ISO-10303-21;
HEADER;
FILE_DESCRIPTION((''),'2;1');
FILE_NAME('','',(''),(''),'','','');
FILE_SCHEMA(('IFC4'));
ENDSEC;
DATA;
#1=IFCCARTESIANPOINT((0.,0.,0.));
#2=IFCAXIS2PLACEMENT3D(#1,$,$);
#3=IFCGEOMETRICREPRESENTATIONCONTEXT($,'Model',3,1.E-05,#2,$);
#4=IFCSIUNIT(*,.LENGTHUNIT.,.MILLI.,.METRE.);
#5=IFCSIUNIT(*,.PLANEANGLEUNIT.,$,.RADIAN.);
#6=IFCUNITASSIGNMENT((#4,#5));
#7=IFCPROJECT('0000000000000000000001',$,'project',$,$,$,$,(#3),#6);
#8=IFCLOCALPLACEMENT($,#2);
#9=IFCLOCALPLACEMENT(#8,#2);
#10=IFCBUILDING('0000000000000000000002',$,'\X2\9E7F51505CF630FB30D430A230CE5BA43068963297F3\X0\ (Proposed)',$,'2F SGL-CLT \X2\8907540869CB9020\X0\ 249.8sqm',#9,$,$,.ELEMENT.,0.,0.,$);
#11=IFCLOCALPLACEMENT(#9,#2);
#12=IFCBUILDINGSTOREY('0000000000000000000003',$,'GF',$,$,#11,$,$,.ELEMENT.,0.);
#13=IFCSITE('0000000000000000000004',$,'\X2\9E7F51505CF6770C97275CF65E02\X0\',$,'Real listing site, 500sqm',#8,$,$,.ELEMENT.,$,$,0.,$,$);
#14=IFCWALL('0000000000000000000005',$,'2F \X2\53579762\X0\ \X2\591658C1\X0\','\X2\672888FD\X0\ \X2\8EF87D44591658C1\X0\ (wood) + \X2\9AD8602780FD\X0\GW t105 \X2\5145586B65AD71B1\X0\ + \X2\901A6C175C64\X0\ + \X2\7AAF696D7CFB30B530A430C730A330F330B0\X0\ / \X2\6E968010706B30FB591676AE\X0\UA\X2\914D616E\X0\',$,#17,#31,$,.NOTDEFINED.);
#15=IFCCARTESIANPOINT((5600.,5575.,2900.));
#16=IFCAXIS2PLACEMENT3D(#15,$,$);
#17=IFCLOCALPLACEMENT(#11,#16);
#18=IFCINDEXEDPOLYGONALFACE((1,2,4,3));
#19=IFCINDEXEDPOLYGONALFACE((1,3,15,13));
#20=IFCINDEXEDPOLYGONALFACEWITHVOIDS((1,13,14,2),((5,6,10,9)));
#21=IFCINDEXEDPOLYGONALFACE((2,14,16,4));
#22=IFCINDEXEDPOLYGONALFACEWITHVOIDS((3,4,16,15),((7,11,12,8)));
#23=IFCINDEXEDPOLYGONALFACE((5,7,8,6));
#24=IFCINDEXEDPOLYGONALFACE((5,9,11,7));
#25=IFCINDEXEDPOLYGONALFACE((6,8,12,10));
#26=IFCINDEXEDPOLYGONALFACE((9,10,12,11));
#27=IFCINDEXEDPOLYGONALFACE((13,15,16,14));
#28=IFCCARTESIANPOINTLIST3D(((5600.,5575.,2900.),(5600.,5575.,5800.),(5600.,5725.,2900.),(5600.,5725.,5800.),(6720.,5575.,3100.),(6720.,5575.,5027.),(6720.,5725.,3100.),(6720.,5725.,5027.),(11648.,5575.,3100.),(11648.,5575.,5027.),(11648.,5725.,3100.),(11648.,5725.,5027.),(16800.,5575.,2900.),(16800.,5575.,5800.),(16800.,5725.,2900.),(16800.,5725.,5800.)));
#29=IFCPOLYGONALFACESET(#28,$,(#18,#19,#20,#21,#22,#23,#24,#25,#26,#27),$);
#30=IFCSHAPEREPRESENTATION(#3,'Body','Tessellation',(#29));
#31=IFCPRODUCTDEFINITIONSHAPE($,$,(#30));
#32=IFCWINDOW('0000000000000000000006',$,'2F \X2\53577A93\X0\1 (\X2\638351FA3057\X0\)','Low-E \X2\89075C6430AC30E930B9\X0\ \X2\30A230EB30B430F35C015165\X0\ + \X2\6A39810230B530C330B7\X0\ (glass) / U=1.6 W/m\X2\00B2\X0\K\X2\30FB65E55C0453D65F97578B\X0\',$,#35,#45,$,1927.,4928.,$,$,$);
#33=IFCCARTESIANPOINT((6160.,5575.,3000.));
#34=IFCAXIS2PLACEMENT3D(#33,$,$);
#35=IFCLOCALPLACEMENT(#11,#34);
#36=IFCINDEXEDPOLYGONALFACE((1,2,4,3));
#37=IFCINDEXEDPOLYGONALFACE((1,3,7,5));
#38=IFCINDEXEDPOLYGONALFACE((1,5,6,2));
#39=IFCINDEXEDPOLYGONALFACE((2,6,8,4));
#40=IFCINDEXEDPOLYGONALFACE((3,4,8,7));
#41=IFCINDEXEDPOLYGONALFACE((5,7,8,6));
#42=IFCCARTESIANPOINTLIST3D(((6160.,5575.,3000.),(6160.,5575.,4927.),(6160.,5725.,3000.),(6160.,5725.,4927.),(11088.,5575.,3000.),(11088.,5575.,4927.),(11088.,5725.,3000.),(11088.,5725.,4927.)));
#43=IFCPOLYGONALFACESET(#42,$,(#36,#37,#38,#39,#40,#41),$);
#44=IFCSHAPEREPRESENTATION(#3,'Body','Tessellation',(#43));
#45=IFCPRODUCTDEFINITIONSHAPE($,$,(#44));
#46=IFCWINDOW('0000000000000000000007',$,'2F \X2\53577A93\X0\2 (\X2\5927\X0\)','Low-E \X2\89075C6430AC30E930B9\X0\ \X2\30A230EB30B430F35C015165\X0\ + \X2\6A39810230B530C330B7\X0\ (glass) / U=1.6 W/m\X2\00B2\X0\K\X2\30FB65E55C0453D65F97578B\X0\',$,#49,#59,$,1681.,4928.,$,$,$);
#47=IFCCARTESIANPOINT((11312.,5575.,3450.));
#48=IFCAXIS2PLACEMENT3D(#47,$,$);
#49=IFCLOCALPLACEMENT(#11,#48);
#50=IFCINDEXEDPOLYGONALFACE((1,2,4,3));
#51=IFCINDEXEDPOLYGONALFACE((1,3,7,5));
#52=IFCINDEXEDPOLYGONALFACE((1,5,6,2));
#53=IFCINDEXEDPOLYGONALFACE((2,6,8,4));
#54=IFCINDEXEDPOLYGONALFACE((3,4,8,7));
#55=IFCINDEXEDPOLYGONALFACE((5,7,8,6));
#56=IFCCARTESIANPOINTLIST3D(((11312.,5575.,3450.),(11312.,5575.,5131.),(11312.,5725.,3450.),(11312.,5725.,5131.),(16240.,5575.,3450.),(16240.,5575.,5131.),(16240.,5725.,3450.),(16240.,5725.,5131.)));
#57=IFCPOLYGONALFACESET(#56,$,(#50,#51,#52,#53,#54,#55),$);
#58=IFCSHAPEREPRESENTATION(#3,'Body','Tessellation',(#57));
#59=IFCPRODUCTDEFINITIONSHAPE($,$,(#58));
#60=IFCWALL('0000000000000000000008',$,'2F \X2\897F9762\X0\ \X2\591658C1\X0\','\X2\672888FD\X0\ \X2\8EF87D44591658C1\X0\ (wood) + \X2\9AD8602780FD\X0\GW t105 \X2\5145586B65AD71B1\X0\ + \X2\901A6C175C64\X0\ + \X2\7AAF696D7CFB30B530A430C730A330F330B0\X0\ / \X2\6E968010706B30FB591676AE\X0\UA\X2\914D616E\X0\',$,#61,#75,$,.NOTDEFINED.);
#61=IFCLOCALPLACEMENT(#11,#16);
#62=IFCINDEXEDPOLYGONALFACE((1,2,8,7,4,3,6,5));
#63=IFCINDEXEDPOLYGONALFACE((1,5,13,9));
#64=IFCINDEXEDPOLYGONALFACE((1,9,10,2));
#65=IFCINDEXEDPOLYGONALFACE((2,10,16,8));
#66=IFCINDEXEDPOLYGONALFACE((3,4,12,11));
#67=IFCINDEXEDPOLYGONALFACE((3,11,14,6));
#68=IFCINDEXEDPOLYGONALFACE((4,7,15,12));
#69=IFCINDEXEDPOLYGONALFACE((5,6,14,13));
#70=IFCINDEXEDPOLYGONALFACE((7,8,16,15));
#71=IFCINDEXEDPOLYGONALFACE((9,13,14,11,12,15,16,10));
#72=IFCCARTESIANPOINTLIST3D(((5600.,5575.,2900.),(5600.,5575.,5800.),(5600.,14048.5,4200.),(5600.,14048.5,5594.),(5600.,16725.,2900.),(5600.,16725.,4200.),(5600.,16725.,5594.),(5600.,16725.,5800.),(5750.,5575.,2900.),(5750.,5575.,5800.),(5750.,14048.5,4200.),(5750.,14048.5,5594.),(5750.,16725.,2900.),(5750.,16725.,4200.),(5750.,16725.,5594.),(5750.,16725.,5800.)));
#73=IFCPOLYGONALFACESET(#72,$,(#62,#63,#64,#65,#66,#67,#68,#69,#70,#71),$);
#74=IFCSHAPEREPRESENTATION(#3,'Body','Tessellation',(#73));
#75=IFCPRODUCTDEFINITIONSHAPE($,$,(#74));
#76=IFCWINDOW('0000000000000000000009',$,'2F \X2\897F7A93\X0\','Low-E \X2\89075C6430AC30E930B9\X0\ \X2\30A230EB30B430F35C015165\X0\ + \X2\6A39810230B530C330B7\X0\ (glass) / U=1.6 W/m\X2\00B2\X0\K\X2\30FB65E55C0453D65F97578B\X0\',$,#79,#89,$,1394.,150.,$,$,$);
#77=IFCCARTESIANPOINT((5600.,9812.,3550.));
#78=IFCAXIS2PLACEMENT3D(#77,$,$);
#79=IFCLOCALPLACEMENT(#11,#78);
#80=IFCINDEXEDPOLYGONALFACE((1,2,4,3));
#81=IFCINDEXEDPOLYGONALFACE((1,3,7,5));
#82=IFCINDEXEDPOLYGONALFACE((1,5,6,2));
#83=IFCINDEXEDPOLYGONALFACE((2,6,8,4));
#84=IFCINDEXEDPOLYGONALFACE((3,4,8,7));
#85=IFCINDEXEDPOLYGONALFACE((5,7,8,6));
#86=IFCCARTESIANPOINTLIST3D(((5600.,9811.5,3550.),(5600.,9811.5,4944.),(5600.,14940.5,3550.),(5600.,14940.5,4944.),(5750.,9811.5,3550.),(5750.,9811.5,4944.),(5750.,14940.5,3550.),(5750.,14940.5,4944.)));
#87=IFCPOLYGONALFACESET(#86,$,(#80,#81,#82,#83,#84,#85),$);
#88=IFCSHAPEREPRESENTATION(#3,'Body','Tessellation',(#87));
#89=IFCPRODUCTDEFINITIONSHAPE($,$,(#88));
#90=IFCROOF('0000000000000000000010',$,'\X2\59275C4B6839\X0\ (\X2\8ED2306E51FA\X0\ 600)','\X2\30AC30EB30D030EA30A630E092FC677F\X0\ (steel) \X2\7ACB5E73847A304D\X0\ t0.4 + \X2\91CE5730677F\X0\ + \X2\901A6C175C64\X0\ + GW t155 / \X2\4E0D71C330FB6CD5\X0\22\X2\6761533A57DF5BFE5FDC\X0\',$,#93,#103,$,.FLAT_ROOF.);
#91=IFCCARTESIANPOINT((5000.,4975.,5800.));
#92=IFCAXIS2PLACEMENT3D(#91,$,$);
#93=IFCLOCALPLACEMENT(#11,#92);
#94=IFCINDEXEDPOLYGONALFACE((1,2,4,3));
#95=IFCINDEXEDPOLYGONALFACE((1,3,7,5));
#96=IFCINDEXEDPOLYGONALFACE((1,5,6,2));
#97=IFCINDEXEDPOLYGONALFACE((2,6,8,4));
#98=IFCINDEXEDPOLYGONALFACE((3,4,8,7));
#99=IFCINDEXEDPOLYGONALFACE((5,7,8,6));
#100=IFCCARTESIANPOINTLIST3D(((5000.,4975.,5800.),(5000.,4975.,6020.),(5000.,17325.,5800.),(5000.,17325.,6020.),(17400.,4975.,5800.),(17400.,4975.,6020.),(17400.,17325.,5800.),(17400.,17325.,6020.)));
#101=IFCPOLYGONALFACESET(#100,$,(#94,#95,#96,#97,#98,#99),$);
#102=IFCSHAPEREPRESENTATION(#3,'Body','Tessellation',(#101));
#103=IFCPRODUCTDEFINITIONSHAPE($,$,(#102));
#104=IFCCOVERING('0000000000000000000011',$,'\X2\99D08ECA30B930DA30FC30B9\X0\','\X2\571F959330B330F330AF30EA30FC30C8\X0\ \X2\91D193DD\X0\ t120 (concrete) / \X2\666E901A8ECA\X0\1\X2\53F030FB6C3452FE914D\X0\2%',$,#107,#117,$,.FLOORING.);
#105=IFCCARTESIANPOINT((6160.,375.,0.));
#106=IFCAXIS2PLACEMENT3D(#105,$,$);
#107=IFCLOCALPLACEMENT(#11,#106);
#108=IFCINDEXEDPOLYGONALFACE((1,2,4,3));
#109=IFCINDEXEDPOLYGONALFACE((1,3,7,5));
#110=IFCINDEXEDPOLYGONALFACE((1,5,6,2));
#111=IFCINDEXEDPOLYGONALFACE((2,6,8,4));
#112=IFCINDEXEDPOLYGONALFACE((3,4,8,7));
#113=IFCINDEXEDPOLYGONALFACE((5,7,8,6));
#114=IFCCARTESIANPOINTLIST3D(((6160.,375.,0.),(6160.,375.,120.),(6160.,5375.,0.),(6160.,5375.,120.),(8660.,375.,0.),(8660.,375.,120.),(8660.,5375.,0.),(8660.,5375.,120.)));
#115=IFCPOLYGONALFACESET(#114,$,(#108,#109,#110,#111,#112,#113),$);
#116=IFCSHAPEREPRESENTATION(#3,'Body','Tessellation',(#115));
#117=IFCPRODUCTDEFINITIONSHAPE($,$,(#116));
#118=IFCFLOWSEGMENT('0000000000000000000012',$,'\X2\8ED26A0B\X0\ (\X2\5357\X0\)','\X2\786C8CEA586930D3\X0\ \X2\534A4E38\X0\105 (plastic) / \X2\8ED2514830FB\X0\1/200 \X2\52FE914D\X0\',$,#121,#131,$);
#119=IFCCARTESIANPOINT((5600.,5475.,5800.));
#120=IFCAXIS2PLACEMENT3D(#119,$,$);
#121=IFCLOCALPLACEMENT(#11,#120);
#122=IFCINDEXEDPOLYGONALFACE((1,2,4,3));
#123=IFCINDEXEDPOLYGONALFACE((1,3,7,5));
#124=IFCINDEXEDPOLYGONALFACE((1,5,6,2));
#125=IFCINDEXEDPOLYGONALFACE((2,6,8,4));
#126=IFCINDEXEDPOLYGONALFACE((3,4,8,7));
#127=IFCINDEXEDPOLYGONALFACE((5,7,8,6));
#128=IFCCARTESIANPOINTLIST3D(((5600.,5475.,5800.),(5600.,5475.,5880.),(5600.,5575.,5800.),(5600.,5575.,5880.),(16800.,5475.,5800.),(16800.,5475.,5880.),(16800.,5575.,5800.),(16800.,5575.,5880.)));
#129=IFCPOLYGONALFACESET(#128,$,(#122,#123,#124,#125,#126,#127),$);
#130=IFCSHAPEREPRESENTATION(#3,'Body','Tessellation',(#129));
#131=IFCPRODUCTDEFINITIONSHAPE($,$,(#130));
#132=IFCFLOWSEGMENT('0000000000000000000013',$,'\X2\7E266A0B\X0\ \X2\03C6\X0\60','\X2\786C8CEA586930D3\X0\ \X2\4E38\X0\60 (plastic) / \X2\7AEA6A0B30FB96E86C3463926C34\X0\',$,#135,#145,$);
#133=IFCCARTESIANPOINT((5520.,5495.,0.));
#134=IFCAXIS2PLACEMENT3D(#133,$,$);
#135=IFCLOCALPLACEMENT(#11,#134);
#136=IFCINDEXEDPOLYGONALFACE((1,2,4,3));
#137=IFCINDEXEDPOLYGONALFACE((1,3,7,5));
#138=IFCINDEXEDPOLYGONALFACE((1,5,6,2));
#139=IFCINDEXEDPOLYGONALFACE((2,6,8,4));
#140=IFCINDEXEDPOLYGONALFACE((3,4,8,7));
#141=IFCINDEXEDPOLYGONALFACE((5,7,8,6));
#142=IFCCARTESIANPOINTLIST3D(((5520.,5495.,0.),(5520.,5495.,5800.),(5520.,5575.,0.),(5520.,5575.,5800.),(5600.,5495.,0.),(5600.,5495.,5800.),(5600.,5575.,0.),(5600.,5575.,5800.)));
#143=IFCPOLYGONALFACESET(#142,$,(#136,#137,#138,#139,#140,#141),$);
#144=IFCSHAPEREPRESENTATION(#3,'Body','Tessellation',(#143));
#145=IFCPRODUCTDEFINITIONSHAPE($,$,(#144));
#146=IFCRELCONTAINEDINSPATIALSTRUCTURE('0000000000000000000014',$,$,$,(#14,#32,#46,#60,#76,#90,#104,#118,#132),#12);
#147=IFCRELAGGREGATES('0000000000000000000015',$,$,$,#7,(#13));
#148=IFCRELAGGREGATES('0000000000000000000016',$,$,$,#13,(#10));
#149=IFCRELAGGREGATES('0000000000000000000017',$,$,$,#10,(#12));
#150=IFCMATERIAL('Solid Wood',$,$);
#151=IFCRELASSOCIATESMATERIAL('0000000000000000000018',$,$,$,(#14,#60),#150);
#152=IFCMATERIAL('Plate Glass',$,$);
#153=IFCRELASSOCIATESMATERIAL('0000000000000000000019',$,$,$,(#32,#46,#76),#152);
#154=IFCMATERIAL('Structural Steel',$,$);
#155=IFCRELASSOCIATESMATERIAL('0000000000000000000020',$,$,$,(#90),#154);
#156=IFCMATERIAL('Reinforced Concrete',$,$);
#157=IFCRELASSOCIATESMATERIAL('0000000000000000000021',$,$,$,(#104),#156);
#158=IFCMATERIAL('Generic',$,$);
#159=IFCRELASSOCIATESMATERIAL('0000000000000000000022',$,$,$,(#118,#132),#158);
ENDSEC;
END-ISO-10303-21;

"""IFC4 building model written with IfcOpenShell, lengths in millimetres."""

from ifc_helpers import new_model, si_unit, frame, frame_2d, origin, place, context, project, spatial, rectangle, extrude, material, element, fill, save


model = new_model("IFC4")

# Units and contexts
model_context = context("Model", 3, precision=1e-05, world=origin())
ifc_project = project(units=[si_unit("LENGTHUNIT", "METRE", prefix="MILLI"), si_unit("PLANEANGLEUNIT", "RADIAN")], contexts=[model_context])

# Site, building, storey
site_placement = place(None, origin())
site = spatial("IfcSite", under=ifc_project, at=site_placement, Name="鹿児島県霧島市", ObjectType="Real listing site, 500sqm", CompositionType="ELEMENT", RefElevation=0.0)
building_placement = place(site_placement, origin())
building = spatial("IfcBuilding", under=site, at=building_placement, Name="鹿児島・ピアノ室と防音 (Proposed)", ObjectType="2F SGL-CLT 複合構造 249.8sqm", CompositionType="ELEMENT", ElevationOfRefHeight=0.0, ElevationOfTerrain=0.0)
storey_placement = place(building_placement, origin())
storey = spatial("IfcBuildingStorey", under=building, at=storey_placement, Name="GF", CompositionType="ELEMENT", Elevation=0.0)

# Shared definitions
ifc_material_1 = material(Name="Solid Wood")

# Shared definitions
ifc_material_2 = material(Name="Reinforced Concrete")

# Shared definitions
ifc_material_3 = material(Name="Plate Glass")

# Wall, openings, windows
wall_1_placement = place(storey_placement, frame((5600.0, 5575.0, 2900.0)))
wall_1 = element("IfcWall", 1, at=wall_1_placement, inside=storey, material=ifc_material_1, Name="2F 南面 外壁", Description="木製 軸組外壁 (wood) + 高性能GW t105 充填断熱 + 通気層 + 窯業系サイディング / 準耐火・外皮UA配慮", PredefinedType="NOTDEFINED", context=model_context, shape_type="SweptSolid", body=[
    extrude(rectangle(XDim=11200.0, YDim=150.0, at=frame_2d((5600.0, 75.0))), frame((5600.0, 5575.0, 2900.0)), (0.0, 0.0, 1.0), 2900.0),
])
opening_1_placement = place(storey_placement, frame((6160.0, 5575.0, 3000.0)))
opening_1 = element("IfcOpeningElement", 2, at=opening_1_placement, cuts=wall_1, PredefinedType="NOTDEFINED", context=model_context, shape_type="SweptSolid", body=[
    extrude(rectangle(XDim=4928.0, YDim=150.0, at=frame_2d((2464.0, 75.0))), frame((6160.0, 5575.0, 3000.0)), (0.0, 0.0, 1.0), 1927.0),
])
opening_2_placement = place(storey_placement, frame((11312.0, 5575.0, 3450.0)))
opening_2 = element("IfcOpeningElement", 3, at=opening_2_placement, cuts=wall_1, PredefinedType="NOTDEFINED", context=model_context, shape_type="SweptSolid", body=[
    extrude(rectangle(XDim=4928.0, YDim=150.0, at=frame_2d((2464.0, 75.0))), frame((11312.0, 5575.0, 3450.0)), (0.0, 0.0, 1.0), 1681.0),
])
window_1_placement = place(storey_placement, frame((6160.0, 5575.0, 3000.0)))
window_1 = element("IfcWindow", 4, at=window_1_placement, inside=storey, material=ifc_material_3, Name="2F 南窓1 (掃出し)", Description="Low-E 複層ガラス アルゴン封入 + 樹脂サッシ (glass) / U=1.6 W/m²K・日射取得型", OverallHeight=1927.0, OverallWidth=4928.0, context=model_context, shape_type="SweptSolid", body=[
    extrude(rectangle(XDim=4928.0, YDim=150.0, at=frame_2d((2464.0, 75.0))), frame((6160.0, 5575.0, 3000.0)), (0.0, 0.0, 1.0), 1927.0),
])
fill(opening_1, window_1)
window_2_placement = place(storey_placement, frame((11312.0, 5575.0, 3450.0)))
window_2 = element("IfcWindow", 5, at=window_2_placement, inside=storey, material=ifc_material_3, Name="2F 南窓2 (大)", Description="Low-E 複層ガラス アルゴン封入 + 樹脂サッシ (glass) / U=1.6 W/m²K・日射取得型", OverallHeight=1681.0, OverallWidth=4928.0, context=model_context, shape_type="SweptSolid", body=[
    extrude(rectangle(XDim=4928.0, YDim=150.0, at=frame_2d((2464.0, 75.0))), frame((11312.0, 5575.0, 3450.0)), (0.0, 0.0, 1.0), 1681.0),
])
fill(opening_2, window_2)

# Wall, opening, window
wall_2_placement = place(storey_placement, frame((5600.0, 5575.0, 2900.0)))
wall_2 = element("IfcWall", 6, at=wall_2_placement, inside=storey, material=ifc_material_1, Name="2F 西面 外壁", Description="木製 軸組外壁 (wood) + 高性能GW t105 充填断熱 + 通気層 + 窯業系サイディング / 準耐火・外皮UA配慮", PredefinedType="NOTDEFINED", context=model_context, shape_type="SweptSolid", body=[
    extrude(rectangle(XDim=150.0, YDim=11150.0, at=frame_2d((75.0, 5575.0))), frame((5600.0, 5575.0, 2900.0)), (0.0, 0.0, 1.0), 2900.0),
])
opening_3_placement = place(storey_placement, frame((5600.0, 9812.0, 3550.0)))
opening_3 = element("IfcOpeningElement", 7, at=opening_3_placement, cuts=wall_2, PredefinedType="NOTDEFINED", context=model_context, shape_type="SweptSolid", body=[
    extrude(rectangle(XDim=150.0, YDim=5129.0, at=frame_2d((75.0, 2564.0))), frame((5600.0, 9812.0, 3550.0)), (0.0, 0.0, 1.0), 1394.0),
])
window_3_placement = place(storey_placement, frame((5600.0, 9812.0, 3550.0)))
window_3 = element("IfcWindow", 8, at=window_3_placement, inside=storey, material=ifc_material_3, Name="2F 西窓", Description="Low-E 複層ガラス アルゴン封入 + 樹脂サッシ (glass) / U=1.6 W/m²K・日射取得型", OverallHeight=1394.0, OverallWidth=150.0, context=model_context, shape_type="SweptSolid", body=[
    extrude(rectangle(XDim=150.0, YDim=5129.0, at=frame_2d((75.0, 2564.0))), frame((5600.0, 9812.0, 3550.0)), (0.0, 0.0, 1.0), 1394.0),
])
fill(opening_3, window_3)

# Roof
ifc_material_4 = material(Name="Structural Steel")
roof_placement = place(storey_placement, frame((5000.0, 4975.0, 5800.0)))
element("IfcRoof", 9, at=roof_placement, inside=storey, material=ifc_material_4, Name="大屋根 (軒の出 600)", Description="ガルバリウム鋼板 (steel) 立平葺き t0.4 + 野地板 + 通気層 + GW t155 / 不燃・法22条区域対応", PredefinedType="FLAT_ROOF", context=model_context, shape_type="SweptSolid", body=[
    extrude(rectangle(XDim=12400.0, YDim=12350.0, at=frame_2d((6200.0, 6175.0))), frame((5000.0, 4975.0, 5800.0)), (0.0, 0.0, 1.0), 220.0),
])

# Covering
covering_placement = place(storey_placement, frame((6160.0, 375.0, 0.0)))
element("IfcCovering", 10, at=covering_placement, inside=storey, material=ifc_material_2, Name="駐車スペース", Description="土間コンクリート 金鏝 t120 (concrete) / 普通車1台・水勾配2%", PredefinedType="FLOORING", context=model_context, shape_type="SweptSolid", body=[
    extrude(rectangle(XDim=2500.0, YDim=5000.0, at=frame_2d((1250.0, 2500.0))), frame((6160.0, 375.0, 0.0)), (0.0, 0.0, 1.0), 120.0),
])

# Flow segments
ifc_material_5 = material(Name="Generic")
flow_segment_1_placement = place(storey_placement, frame((5600.0, 5475.0, 5800.0)))
element("IfcFlowSegment", 11, at=flow_segment_1_placement, inside=storey, material=ifc_material_5, Name="軒樋 (南)", Description="硬質塩ビ 半丸105 (plastic) / 軒先・1/200 勾配", context=model_context, shape_type="SweptSolid", body=[
    extrude(rectangle(XDim=11200.0, YDim=100.0, at=frame_2d((5600.0, 50.0))), frame((5600.0, 5475.0, 5800.0)), (0.0, 0.0, 1.0), 80.0),
])
flow_segment_2_placement = place(storey_placement, frame((5520.0, 5495.0, 0.0)))
element("IfcFlowSegment", 12, at=flow_segment_2_placement, inside=storey, material=ifc_material_5, Name="縦樋 φ60", Description="硬質塩ビ 丸60 (plastic) / 竪樋・雨水排水", context=model_context, shape_type="SweptSolid", body=[
    extrude(rectangle(XDim=80.0, YDim=80.0, at=frame_2d((40.0, 40.0))), frame((5520.0, 5495.0, 0.0)), (0.0, 0.0, 1.0), 5800.0),
])

save(model, "model.ifc")
